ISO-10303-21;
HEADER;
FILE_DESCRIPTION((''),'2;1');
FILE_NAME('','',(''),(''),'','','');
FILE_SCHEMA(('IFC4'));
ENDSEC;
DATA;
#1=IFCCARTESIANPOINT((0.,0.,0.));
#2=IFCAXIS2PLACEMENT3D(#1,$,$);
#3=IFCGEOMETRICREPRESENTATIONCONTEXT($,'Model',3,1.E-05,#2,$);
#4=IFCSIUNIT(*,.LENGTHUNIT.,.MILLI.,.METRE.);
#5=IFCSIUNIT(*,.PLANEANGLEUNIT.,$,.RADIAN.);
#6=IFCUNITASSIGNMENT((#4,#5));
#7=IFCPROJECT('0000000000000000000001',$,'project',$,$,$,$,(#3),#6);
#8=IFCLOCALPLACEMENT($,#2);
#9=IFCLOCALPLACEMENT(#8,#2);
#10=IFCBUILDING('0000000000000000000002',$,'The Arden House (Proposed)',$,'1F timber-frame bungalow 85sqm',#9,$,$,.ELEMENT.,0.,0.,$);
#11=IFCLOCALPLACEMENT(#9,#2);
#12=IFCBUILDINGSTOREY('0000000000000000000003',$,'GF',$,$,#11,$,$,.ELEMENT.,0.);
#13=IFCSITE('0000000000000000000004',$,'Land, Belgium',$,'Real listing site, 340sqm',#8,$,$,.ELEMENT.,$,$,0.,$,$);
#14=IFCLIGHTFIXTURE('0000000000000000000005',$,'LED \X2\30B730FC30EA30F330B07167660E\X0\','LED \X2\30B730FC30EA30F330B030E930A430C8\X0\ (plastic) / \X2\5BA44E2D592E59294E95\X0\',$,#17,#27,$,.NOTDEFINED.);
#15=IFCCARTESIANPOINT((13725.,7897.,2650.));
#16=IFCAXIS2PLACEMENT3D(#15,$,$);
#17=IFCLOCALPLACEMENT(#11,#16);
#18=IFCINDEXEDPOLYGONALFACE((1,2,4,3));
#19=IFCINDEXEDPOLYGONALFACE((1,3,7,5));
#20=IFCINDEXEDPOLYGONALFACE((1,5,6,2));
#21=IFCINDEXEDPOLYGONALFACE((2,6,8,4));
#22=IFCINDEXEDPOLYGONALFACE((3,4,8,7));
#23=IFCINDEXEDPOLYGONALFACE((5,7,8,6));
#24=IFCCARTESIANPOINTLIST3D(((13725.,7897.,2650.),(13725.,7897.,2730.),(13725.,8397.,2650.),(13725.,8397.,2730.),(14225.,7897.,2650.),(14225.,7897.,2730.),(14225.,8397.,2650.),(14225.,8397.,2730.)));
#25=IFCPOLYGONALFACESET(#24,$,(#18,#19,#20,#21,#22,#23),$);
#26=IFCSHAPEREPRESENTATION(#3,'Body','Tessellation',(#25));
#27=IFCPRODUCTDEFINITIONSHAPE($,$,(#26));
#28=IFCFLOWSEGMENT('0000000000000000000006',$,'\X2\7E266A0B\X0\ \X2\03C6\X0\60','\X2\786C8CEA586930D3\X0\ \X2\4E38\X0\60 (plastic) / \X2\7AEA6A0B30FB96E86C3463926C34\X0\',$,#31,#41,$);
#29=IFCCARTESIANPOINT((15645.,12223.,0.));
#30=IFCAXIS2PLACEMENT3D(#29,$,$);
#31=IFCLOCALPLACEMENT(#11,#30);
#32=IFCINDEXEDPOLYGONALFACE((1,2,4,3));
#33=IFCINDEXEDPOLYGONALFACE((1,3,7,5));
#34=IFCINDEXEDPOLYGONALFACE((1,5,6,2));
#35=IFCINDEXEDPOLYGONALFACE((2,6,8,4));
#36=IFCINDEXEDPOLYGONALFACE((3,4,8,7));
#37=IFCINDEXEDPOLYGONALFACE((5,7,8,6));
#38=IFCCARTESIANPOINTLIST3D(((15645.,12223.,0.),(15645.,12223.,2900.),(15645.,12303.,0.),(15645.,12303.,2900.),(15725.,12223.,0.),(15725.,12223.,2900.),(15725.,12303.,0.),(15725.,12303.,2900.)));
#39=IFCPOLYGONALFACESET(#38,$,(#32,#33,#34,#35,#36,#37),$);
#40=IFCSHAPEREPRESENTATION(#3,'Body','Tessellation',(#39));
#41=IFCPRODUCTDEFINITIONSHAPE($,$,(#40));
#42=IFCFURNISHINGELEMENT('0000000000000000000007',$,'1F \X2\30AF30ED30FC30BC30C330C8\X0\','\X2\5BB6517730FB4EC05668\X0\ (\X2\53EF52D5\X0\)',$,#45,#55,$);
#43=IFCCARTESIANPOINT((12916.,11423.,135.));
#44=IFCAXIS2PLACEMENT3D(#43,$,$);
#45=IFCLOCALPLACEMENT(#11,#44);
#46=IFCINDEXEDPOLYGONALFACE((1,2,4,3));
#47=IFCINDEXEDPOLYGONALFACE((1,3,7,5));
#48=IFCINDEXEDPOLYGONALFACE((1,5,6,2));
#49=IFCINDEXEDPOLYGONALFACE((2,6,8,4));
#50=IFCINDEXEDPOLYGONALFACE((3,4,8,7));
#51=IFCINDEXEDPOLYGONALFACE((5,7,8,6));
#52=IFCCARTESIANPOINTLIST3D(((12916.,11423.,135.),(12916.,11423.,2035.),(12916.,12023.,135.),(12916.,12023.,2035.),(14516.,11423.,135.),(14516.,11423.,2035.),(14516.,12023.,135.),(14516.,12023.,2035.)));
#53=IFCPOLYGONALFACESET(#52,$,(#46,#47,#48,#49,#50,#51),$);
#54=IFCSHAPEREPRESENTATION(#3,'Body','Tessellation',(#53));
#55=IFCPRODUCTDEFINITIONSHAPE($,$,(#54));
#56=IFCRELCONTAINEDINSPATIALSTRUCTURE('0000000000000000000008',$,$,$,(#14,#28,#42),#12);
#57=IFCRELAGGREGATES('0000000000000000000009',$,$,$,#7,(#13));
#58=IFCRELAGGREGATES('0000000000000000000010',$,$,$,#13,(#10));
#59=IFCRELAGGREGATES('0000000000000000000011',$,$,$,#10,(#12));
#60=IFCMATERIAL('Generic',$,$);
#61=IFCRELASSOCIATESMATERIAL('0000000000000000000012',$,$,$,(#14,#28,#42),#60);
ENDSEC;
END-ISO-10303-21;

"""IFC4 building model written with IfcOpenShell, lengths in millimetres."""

from ifc_helpers import new_model, si_unit, frame, frame_2d, origin, place, context, project, spatial, rectangle, extrude, material, element, save


model = new_model("IFC4")

# Units and contexts
model_context = context("Model", 3, precision=1e-05, world=origin())
ifc_project = project(units=[si_unit("LENGTHUNIT", "METRE", prefix="MILLI"), si_unit("PLANEANGLEUNIT", "RADIAN")], contexts=[model_context])

# Site, building, storey
site_placement = place(None, origin())
site = spatial("IfcSite", under=ifc_project, at=site_placement, Name="Land, Belgium", ObjectType="Real listing site, 340sqm", CompositionType="ELEMENT", RefElevation=0.0)
building_placement = place(site_placement, origin())
building = spatial("IfcBuilding", under=site, at=building_placement, Name="The Arden House (Proposed)", ObjectType="1F timber-frame bungalow 85sqm", CompositionType="ELEMENT", ElevationOfRefHeight=0.0, ElevationOfTerrain=0.0)
storey_placement = place(building_placement, origin())
storey = spatial("IfcBuildingStorey", under=building, at=storey_placement, Name="GF", CompositionType="ELEMENT", Elevation=0.0)

# Shared definitions
ifc_material_1 = material(Name="Generic")

# Light fixture
light_fixture_1_placement = place(storey_placement, frame((13725.0, 7897.0, 2650.0)))
element("IfcLightFixture", 1, at=light_fixture_1_placement, inside=storey, material=ifc_material_1, Name="LED シーリング照明", Description="LED シーリングライト (plastic) / 室中央天井", PredefinedType="NOTDEFINED", context=model_context, shape_type="SweptSolid", body=[
    extrude(rectangle(XDim=500.0, YDim=500.0, at=frame_2d((250.0, 250.0))), frame((13725.0, 7897.0, 2650.0)), (0.0, 0.0, 1.0), 80.0),
])

# Flow segment
flow_segment_placement = place(storey_placement, frame((15645.0, 12223.0, 0.0)))
element("IfcFlowSegment", 2, at=flow_segment_placement, inside=storey, material=ifc_material_1, Name="縦樋 φ60", Description="硬質塩ビ 丸60 (plastic) / 竪樋・雨水排水", context=model_context, shape_type="SweptSolid", body=[
    extrude(rectangle(XDim=80.0, YDim=80.0, at=frame_2d((40.0, 40.0))), frame((15645.0, 12223.0, 0.0)), (0.0, 0.0, 1.0), 2900.0),
])

# Furnishing element
furnishing_placement = place(storey_placement, frame((12916.0, 11423.0, 135.0)))
element("IfcFurnishingElement", 3, at=furnishing_placement, inside=storey, material=ifc_material_1, Name="1F クローゼット", Description="家具・什器 (可動)", context=model_context, shape_type="SweptSolid", body=[
    extrude(rectangle(XDim=1600.0, YDim=600.0, at=frame_2d((800.0, 300.0))), frame((12916.0, 11423.0, 135.0)), (0.0, 0.0, 1.0), 1900.0),
])

save(model, "model.ifc")
